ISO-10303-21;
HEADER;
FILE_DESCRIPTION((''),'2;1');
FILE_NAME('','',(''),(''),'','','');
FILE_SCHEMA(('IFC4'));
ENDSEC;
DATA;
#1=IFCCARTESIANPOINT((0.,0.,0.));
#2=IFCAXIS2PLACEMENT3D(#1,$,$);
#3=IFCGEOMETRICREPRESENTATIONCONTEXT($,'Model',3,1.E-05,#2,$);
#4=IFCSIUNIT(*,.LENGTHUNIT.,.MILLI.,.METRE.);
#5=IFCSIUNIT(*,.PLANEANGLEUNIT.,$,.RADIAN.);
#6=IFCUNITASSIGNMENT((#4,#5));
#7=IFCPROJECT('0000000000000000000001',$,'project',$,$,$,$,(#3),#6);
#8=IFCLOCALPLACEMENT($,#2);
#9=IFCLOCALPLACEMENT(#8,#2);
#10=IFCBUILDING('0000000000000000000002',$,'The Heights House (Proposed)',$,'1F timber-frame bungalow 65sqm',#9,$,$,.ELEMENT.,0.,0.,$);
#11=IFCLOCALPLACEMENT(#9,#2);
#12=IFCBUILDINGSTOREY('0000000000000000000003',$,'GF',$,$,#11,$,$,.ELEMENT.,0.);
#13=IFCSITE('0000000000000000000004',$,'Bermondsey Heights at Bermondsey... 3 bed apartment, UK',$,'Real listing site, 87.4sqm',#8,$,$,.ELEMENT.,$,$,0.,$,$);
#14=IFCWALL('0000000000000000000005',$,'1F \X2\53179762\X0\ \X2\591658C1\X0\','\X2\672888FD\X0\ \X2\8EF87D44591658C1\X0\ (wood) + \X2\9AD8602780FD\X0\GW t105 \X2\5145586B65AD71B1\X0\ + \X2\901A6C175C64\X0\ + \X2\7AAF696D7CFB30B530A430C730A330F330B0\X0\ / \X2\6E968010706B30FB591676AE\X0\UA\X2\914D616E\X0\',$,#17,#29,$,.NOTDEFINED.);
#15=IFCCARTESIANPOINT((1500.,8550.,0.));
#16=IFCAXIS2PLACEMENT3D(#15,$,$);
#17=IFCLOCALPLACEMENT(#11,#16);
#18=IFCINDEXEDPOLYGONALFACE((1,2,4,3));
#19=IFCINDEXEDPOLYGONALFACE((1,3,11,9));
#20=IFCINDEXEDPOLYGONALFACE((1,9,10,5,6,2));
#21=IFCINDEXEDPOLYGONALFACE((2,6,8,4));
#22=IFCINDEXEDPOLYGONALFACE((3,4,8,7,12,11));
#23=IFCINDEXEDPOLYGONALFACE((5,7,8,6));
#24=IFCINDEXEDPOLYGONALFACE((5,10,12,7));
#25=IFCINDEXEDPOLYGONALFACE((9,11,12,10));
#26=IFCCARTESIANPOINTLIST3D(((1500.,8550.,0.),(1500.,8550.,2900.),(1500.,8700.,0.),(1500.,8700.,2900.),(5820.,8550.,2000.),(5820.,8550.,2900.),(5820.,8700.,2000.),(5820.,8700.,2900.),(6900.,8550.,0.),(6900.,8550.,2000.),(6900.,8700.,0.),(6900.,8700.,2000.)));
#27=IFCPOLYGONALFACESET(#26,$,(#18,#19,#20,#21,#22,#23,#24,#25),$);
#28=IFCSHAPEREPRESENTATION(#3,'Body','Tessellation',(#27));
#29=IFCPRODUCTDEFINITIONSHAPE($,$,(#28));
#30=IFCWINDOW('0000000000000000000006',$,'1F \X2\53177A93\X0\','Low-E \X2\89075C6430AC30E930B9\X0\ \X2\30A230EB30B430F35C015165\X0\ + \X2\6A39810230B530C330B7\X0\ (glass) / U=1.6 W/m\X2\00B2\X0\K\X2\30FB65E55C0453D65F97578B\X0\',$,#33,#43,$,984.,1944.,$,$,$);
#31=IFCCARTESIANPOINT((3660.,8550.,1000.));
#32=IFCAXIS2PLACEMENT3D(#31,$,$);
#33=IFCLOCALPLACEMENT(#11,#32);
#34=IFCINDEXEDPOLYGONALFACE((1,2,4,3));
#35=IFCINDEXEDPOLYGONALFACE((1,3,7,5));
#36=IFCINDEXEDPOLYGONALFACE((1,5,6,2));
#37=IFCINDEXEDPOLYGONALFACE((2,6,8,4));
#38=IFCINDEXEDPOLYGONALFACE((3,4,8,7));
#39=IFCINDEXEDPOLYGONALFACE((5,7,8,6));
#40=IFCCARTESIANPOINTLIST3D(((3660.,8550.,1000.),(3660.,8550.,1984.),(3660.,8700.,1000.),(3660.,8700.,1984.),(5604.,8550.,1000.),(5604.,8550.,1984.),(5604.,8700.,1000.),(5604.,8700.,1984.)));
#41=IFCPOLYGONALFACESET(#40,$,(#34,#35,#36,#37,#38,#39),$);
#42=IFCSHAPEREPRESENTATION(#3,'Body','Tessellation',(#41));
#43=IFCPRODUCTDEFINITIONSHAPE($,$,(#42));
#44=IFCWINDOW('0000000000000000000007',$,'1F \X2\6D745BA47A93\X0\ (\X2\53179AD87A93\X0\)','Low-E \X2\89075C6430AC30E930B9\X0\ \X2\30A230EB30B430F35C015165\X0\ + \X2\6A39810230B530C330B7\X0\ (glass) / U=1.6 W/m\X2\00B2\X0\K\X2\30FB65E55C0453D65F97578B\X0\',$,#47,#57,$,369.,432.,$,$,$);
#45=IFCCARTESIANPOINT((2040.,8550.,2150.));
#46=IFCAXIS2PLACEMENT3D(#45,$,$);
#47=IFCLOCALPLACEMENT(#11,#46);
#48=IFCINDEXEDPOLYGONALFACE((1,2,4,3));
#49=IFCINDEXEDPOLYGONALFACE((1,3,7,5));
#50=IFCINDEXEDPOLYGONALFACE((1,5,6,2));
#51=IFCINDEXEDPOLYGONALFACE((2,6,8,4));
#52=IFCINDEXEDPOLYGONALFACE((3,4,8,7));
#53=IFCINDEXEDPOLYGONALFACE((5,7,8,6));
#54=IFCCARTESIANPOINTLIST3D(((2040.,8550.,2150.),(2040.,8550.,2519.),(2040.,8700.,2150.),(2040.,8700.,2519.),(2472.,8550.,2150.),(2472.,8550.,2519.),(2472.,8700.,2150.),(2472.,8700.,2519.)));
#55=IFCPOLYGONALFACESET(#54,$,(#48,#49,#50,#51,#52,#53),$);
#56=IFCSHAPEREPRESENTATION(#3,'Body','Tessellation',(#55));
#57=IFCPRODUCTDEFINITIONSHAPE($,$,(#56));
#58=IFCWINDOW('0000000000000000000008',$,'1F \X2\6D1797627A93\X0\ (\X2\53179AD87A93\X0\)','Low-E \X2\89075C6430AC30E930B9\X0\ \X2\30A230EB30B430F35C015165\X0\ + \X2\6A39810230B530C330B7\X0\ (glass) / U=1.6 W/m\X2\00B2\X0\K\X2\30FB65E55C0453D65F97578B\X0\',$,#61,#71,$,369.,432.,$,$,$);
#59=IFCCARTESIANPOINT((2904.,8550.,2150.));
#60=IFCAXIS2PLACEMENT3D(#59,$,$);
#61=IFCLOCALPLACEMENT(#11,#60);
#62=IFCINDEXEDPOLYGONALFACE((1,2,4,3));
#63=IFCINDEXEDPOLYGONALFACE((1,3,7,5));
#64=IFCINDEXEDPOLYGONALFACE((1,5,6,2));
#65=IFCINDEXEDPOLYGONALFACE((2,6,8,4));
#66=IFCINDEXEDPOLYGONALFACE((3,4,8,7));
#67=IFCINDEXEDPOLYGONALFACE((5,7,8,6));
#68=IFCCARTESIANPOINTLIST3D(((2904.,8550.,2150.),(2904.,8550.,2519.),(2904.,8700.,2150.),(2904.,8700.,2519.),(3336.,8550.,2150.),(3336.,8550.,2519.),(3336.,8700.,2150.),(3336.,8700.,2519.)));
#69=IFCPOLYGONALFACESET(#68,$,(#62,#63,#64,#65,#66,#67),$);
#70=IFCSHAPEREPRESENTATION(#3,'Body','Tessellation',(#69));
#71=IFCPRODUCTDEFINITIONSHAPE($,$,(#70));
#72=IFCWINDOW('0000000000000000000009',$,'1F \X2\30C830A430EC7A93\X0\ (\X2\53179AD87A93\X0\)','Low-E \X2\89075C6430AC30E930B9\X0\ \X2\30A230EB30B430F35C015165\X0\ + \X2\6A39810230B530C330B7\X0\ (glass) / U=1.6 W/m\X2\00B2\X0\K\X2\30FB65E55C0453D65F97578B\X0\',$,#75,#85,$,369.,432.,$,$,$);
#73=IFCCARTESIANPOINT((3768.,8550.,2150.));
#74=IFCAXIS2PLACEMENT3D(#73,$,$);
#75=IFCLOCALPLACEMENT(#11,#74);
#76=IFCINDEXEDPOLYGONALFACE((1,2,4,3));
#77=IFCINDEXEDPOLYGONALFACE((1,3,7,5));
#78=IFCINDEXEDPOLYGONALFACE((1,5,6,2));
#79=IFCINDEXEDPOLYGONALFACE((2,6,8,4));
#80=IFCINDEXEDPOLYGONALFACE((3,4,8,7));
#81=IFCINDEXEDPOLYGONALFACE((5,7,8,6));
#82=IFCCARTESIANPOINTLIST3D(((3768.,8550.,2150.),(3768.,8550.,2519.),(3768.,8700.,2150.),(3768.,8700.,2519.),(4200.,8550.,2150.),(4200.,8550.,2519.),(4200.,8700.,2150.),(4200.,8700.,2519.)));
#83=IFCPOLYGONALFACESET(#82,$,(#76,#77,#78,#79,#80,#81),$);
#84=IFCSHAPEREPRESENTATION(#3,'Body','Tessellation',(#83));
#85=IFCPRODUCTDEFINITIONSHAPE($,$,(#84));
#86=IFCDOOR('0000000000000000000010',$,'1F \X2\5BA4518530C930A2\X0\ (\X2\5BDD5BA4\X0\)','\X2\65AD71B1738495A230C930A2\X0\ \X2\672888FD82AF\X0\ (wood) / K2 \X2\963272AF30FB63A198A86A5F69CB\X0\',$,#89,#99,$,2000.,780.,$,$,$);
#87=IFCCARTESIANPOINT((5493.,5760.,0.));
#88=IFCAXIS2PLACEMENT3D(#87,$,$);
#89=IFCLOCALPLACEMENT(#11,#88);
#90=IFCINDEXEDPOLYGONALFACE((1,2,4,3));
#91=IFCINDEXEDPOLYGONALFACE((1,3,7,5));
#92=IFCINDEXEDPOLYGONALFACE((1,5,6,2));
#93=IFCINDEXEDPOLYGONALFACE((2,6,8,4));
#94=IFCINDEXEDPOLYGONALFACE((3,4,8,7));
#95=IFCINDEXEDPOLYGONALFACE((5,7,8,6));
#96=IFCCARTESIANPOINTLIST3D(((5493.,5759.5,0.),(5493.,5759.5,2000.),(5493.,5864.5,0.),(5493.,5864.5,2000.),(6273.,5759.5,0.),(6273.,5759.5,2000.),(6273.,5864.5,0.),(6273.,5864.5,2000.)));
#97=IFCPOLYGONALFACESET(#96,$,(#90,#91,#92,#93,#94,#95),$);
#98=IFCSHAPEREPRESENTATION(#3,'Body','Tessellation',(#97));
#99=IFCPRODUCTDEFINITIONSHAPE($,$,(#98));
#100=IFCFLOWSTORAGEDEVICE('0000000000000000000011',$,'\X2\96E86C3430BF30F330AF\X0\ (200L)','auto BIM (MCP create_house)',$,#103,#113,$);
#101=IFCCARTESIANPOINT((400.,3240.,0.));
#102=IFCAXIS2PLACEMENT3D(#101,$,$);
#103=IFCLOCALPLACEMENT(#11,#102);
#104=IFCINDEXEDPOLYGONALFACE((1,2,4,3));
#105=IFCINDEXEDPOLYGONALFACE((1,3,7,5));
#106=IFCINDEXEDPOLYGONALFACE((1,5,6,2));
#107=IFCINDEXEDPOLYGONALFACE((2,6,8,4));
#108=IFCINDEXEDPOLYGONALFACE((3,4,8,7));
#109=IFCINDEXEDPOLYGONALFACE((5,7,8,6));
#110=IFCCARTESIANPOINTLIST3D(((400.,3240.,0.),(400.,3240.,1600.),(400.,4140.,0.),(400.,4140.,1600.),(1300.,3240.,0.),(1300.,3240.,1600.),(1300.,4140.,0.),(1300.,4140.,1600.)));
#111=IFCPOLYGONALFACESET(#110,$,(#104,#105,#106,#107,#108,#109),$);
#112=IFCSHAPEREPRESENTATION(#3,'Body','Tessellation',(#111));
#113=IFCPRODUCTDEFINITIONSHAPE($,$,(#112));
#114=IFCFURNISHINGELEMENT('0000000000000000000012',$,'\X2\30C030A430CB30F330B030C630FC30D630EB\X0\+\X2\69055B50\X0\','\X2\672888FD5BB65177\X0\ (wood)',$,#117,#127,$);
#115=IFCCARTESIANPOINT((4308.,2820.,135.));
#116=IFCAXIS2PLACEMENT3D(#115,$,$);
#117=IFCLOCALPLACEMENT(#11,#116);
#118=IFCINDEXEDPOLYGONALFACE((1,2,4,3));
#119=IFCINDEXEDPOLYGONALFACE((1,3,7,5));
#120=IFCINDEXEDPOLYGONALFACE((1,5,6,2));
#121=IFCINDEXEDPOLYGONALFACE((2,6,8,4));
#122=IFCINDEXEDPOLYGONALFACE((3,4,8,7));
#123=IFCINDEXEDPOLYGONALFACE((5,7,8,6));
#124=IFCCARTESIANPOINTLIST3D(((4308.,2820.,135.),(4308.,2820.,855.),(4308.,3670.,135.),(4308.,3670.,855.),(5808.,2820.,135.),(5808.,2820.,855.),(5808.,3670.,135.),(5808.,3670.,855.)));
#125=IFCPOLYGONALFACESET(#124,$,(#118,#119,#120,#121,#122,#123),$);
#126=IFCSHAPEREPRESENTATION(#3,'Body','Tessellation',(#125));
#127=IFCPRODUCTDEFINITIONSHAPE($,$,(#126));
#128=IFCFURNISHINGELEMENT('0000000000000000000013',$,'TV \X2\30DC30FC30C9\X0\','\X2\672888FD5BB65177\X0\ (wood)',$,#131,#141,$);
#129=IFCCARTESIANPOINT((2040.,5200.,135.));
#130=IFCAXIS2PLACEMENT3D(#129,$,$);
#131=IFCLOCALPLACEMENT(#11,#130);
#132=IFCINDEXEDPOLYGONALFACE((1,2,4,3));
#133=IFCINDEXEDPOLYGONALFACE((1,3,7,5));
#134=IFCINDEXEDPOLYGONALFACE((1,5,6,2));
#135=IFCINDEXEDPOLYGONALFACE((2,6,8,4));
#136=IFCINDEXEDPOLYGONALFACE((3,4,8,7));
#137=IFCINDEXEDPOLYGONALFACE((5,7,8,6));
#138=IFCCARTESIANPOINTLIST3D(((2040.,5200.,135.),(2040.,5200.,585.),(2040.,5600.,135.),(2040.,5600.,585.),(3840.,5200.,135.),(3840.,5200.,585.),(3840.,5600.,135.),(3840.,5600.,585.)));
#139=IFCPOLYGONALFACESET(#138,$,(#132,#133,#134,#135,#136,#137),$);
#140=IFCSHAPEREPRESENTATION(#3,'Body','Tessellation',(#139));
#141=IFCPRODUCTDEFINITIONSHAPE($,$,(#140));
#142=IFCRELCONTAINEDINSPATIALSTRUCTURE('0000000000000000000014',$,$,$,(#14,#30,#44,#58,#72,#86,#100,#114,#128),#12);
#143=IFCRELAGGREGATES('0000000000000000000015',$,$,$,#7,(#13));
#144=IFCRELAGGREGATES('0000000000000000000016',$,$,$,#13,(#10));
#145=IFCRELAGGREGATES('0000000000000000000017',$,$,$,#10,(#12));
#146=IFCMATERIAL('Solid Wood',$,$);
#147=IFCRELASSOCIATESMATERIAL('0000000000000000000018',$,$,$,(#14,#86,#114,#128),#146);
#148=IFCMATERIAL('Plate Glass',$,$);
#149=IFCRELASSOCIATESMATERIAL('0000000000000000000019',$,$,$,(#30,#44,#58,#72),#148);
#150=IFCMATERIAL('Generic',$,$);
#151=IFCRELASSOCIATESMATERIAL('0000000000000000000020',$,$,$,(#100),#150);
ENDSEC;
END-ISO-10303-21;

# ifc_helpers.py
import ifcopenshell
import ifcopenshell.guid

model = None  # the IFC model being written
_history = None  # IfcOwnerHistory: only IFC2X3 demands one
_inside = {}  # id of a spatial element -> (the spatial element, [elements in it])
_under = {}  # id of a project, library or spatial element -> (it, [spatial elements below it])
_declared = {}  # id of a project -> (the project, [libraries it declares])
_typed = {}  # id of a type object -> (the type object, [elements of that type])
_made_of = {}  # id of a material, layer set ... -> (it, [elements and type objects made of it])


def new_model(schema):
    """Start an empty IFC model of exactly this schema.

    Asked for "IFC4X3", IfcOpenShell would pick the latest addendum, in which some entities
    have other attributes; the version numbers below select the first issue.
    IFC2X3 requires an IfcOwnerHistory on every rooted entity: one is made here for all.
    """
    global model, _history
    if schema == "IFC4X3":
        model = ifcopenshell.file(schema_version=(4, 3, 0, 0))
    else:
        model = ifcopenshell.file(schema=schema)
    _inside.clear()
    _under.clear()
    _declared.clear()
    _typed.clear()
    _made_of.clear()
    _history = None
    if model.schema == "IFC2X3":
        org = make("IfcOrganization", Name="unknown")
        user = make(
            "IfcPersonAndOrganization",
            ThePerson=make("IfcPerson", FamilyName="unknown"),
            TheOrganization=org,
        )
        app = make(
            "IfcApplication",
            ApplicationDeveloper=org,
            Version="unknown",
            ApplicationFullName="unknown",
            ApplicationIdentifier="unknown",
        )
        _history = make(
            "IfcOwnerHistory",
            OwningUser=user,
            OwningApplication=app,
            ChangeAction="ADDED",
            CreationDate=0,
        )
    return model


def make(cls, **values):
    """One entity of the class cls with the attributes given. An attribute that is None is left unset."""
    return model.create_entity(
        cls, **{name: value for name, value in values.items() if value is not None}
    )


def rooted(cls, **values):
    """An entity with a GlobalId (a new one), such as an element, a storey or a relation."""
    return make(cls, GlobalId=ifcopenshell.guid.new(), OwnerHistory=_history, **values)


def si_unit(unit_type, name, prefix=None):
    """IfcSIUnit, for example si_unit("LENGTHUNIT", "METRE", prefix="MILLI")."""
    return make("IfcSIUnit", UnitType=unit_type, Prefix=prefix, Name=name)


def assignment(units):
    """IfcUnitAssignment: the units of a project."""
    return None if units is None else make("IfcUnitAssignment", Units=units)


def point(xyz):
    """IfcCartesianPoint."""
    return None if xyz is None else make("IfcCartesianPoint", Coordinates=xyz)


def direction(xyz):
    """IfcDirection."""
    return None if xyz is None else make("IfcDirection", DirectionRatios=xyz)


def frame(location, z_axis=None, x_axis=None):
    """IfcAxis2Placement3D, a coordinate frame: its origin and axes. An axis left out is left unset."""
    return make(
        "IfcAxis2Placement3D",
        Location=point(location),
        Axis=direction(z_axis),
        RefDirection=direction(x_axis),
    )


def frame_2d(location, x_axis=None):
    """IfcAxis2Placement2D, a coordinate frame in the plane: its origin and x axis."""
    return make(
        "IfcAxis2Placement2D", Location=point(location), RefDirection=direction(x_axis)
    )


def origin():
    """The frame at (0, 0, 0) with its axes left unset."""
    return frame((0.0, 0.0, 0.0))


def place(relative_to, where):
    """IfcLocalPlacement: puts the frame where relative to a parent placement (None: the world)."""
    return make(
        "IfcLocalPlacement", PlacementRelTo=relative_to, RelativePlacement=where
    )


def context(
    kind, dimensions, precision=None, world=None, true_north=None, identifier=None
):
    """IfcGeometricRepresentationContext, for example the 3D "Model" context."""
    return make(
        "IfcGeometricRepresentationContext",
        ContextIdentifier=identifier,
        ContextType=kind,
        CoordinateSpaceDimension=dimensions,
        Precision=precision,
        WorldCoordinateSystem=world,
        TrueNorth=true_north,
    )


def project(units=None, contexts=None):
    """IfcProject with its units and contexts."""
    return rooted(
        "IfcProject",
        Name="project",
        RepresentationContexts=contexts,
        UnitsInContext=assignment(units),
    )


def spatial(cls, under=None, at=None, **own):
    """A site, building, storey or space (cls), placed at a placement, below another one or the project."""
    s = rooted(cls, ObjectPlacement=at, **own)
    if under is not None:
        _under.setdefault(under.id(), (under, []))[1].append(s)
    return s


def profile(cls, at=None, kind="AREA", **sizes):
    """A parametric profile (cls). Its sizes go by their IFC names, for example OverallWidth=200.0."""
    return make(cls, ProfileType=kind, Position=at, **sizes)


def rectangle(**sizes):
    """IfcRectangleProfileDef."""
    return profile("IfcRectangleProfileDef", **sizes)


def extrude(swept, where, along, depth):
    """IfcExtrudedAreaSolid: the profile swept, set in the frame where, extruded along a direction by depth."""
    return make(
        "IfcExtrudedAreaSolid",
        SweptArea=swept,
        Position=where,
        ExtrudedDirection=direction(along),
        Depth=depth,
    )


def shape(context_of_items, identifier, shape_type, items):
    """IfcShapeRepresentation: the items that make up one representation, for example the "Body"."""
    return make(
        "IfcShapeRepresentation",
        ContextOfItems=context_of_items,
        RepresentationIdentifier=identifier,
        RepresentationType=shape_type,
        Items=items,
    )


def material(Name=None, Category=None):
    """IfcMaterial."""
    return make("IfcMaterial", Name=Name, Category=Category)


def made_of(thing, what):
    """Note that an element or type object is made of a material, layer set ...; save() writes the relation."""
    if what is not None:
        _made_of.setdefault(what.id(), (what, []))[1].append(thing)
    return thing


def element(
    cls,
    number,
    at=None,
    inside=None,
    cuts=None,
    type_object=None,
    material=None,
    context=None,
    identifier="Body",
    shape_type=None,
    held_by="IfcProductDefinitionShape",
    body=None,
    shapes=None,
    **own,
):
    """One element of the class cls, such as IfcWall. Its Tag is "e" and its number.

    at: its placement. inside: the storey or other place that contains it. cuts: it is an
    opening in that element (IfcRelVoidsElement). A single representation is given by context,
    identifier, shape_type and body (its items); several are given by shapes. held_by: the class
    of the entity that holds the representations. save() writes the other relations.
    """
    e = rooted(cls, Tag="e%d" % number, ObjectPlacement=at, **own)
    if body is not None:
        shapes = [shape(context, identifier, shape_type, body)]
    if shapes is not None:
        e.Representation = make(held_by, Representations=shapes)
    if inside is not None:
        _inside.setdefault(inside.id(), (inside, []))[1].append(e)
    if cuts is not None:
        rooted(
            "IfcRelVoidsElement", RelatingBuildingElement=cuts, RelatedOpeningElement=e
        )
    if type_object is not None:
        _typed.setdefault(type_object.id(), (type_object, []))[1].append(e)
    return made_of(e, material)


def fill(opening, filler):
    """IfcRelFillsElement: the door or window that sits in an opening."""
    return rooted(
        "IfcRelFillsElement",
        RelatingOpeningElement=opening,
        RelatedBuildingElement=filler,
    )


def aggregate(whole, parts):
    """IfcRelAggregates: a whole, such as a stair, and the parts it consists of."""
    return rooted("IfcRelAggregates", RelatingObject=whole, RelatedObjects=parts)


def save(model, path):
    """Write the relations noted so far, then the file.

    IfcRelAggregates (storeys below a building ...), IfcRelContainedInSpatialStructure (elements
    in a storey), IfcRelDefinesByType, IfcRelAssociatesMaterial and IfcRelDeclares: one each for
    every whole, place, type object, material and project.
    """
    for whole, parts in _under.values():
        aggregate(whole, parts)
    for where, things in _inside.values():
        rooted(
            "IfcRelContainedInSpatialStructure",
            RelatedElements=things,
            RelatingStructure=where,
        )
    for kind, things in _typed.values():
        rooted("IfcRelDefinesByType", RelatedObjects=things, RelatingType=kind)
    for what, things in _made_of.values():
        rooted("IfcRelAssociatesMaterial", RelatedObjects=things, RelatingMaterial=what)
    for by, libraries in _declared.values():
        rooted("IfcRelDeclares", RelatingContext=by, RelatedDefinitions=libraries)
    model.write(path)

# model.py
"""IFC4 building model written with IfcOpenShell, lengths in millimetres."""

from ifc_helpers import new_model, si_unit, frame, frame_2d, origin, place, context, project, spatial, rectangle, extrude, material, element, fill, save


model = new_model("IFC4")

# Units and contexts
model_context = context("Model", 3, precision=1e-05, world=origin())
ifc_project = project(units=[si_unit("LENGTHUNIT", "METRE", prefix="MILLI"), si_unit("PLANEANGLEUNIT", "RADIAN")], contexts=[model_context])

# Site, building, storey
site_placement = place(None, origin())
site = spatial("IfcSite", under=ifc_project, at=site_placement, Name="Bermondsey Heights at Bermondsey... 3 bed apartment, UK", ObjectType="Real listing site, 87.4sqm", CompositionType="ELEMENT", RefElevation=0.0)
building_placement = place(site_placement, origin())
building = spatial("IfcBuilding", under=site, at=building_placement, Name="The Heights House (Proposed)", ObjectType="1F timber-frame bungalow 65sqm", CompositionType="ELEMENT", ElevationOfRefHeight=0.0, ElevationOfTerrain=0.0)
storey_placement = place(building_placement, origin())
storey = spatial("IfcBuildingStorey", under=building, at=storey_placement, Name="GF", CompositionType="ELEMENT", Elevation=0.0)

# Wall, openings, windows
ifc_material_1 = material(Name="Solid Wood")
wall_1_placement = place(storey_placement, frame((1500.0, 8550.0, 0.0)))
wall_1 = element("IfcWall", 1, at=wall_1_placement, inside=storey, material=ifc_material_1, Name="1F 北面 外壁", Description="木製 軸組外壁 (wood) + 高性能GW t105 充填断熱 + 通気層 + 窯業系サイディング / 準耐火・外皮UA配慮", PredefinedType="NOTDEFINED", context=model_context, shape_type="SweptSolid", body=[
    extrude(rectangle(XDim=5400.0, YDim=150.0, at=frame_2d((2700.0, 75.0))), frame((1500.0, 8550.0, 0.0)), (0.0, 0.0, 1.0), 2900.0),
])
opening_1_placement = place(storey_placement, frame((3660.0, 8550.0, 1000.0)))
opening_1 = element("IfcOpeningElement", 2, at=opening_1_placement, cuts=wall_1, PredefinedType="NOTDEFINED", context=model_context, shape_type="SweptSolid", body=[
    extrude(rectangle(XDim=1944.0, YDim=150.0, at=frame_2d((972.0, 75.0))), frame((3660.0, 8550.0, 1000.0)), (0.0, 0.0, 1.0), 984.0),
])
opening_2_placement = place(storey_placement, frame((2040.0, 8550.0, 2150.0)))
opening_2 = element("IfcOpeningElement", 3, at=opening_2_placement, cuts=wall_1, PredefinedType="NOTDEFINED", context=model_context, shape_type="SweptSolid", body=[
    extrude(rectangle(XDim=432.0, YDim=150.0, at=frame_2d((216.0, 75.0))), frame((2040.0, 8550.0, 2150.0)), (0.0, 0.0, 1.0), 369.0),
])
opening_3_placement = place(storey_placement, frame((2904.0, 8550.0, 2150.0)))
opening_3 = element("IfcOpeningElement", 4, at=opening_3_placement, cuts=wall_1, PredefinedType="NOTDEFINED", context=model_context, shape_type="SweptSolid", body=[
    extrude(rectangle(XDim=432.0, YDim=150.0, at=frame_2d((216.0, 75.0))), frame((2904.0, 8550.0, 2150.0)), (0.0, 0.0, 1.0), 369.0),
])
opening_4_placement = place(storey_placement, frame((3768.0, 8550.0, 2150.0)))
opening_4 = element("IfcOpeningElement", 5, at=opening_4_placement, cuts=wall_1, PredefinedType="NOTDEFINED", context=model_context, shape_type="SweptSolid", body=[
    extrude(rectangle(XDim=432.0, YDim=150.0, at=frame_2d((216.0, 75.0))), frame((3768.0, 8550.0, 2150.0)), (0.0, 0.0, 1.0), 369.0),
])
ifc_material_2 = material(Name="Plate Glass")
window_1_placement = place(storey_placement, frame((3660.0, 8550.0, 1000.0)))
window_1 = element("IfcWindow", 6, at=window_1_placement, inside=storey, material=ifc_material_2, Name="1F 北窓", Description="Low-E 複層ガラス アルゴン封入 + 樹脂サッシ (glass) / U=1.6 W/m²K・日射取得型", OverallHeight=984.0, OverallWidth=1944.0, context=model_context, shape_type="SweptSolid", body=[
    extrude(rectangle(XDim=1944.0, YDim=150.0, at=frame_2d((972.0, 75.0))), frame((3660.0, 8550.0, 1000.0)), (0.0, 0.0, 1.0), 984.0),
])
fill(opening_1, window_1)
window_2_placement = place(storey_placement, frame((2040.0, 8550.0, 2150.0)))
window_2 = element("IfcWindow", 7, at=window_2_placement, inside=storey, material=ifc_material_2, Name="1F 浴室窓 (北高窓)", Description="Low-E 複層ガラス アルゴン封入 + 樹脂サッシ (glass) / U=1.6 W/m²K・日射取得型", OverallHeight=369.0, OverallWidth=432.0, context=model_context, shape_type="SweptSolid", body=[
    extrude(rectangle(XDim=432.0, YDim=150.0, at=frame_2d((216.0, 75.0))), frame((2040.0, 8550.0, 2150.0)), (0.0, 0.0, 1.0), 369.0),
])
fill(opening_2, window_2)
window_3_placement = place(storey_placement, frame((2904.0, 8550.0, 2150.0)))
window_3 = element("IfcWindow", 8, at=window_3_placement, inside=storey, material=ifc_material_2, Name="1F 洗面窓 (北高窓)", Description="Low-E 複層ガラス アルゴン封入 + 樹脂サッシ (glass) / U=1.6 W/m²K・日射取得型", OverallHeight=369.0, OverallWidth=432.0, context=model_context, shape_type="SweptSolid", body=[
    extrude(rectangle(XDim=432.0, YDim=150.0, at=frame_2d((216.0, 75.0))), frame((2904.0, 8550.0, 2150.0)), (0.0, 0.0, 1.0), 369.0),
])
fill(opening_3, window_3)
window_4_placement = place(storey_placement, frame((3768.0, 8550.0, 2150.0)))
window_4 = element("IfcWindow", 9, at=window_4_placement, inside=storey, material=ifc_material_2, Name="1F トイレ窓 (北高窓)", Description="Low-E 複層ガラス アルゴン封入 + 樹脂サッシ (glass) / U=1.6 W/m²K・日射取得型", OverallHeight=369.0, OverallWidth=432.0, context=model_context, shape_type="SweptSolid", body=[
    extrude(rectangle(XDim=432.0, YDim=150.0, at=frame_2d((216.0, 75.0))), frame((3768.0, 8550.0, 2150.0)), (0.0, 0.0, 1.0), 369.0),
])
fill(opening_4, window_4)

# Door
door_1_placement = place(storey_placement, frame((5493.0, 5760.0, 0.0)))
element("IfcDoor", 10, at=door_1_placement, inside=storey, material=ifc_material_1, Name="1F 室内ドア (寝室)", Description="断熱玄関ドア 木製芯 (wood) / K2 防犯・採風機構", OverallHeight=2000.0, OverallWidth=780.0, context=model_context, shape_type="SweptSolid", body=[
    extrude(rectangle(XDim=780.0, YDim=105.0, at=frame_2d((390.0, 52.0))), frame((5493.0, 5760.0, 0.0)), (0.0, 0.0, 1.0), 2000.0),
])

# Flow storage device
ifc_material_3 = material(Name="Generic")
flow_storage_device_placement = place(storey_placement, frame((400.0, 3240.0, 0.0)))
element("IfcFlowStorageDevice", 11, at=flow_storage_device_placement, inside=storey, material=ifc_material_3, Name="雨水タンク (200L)", Description="auto BIM (MCP create_house)", context=model_context, shape_type="SweptSolid", body=[
    extrude(rectangle(XDim=900.0, YDim=900.0, at=frame_2d((450.0, 450.0))), frame((400.0, 3240.0, 0.0)), (0.0, 0.0, 1.0), 1600.0),
])

# Furnishing elements
furnishing_1_placement = place(storey_placement, frame((4308.0, 2820.0, 135.0)))
element("IfcFurnishingElement", 12, at=furnishing_1_placement, inside=storey, material=ifc_material_1, Name="ダイニングテーブル+椅子", Description="木製家具 (wood)", context=model_context, shape_type="SweptSolid", body=[
    extrude(rectangle(XDim=1500.0, YDim=850.0, at=frame_2d((750.0, 425.0))), frame((4308.0, 2820.0, 135.0)), (0.0, 0.0, 1.0), 720.0),
])
furnishing_2_placement = place(storey_placement, frame((2040.0, 5200.0, 135.0)))
element("IfcFurnishingElement", 13, at=furnishing_2_placement, inside=storey, material=ifc_material_1, Name="TV ボード", Description="木製家具 (wood)", context=model_context, shape_type="SweptSolid", body=[
    extrude(rectangle(XDim=1800.0, YDim=400.0, at=frame_2d((900.0, 200.0))), frame((2040.0, 5200.0, 135.0)), (0.0, 0.0, 1.0), 450.0),
])

save(model, "model.ifc")
